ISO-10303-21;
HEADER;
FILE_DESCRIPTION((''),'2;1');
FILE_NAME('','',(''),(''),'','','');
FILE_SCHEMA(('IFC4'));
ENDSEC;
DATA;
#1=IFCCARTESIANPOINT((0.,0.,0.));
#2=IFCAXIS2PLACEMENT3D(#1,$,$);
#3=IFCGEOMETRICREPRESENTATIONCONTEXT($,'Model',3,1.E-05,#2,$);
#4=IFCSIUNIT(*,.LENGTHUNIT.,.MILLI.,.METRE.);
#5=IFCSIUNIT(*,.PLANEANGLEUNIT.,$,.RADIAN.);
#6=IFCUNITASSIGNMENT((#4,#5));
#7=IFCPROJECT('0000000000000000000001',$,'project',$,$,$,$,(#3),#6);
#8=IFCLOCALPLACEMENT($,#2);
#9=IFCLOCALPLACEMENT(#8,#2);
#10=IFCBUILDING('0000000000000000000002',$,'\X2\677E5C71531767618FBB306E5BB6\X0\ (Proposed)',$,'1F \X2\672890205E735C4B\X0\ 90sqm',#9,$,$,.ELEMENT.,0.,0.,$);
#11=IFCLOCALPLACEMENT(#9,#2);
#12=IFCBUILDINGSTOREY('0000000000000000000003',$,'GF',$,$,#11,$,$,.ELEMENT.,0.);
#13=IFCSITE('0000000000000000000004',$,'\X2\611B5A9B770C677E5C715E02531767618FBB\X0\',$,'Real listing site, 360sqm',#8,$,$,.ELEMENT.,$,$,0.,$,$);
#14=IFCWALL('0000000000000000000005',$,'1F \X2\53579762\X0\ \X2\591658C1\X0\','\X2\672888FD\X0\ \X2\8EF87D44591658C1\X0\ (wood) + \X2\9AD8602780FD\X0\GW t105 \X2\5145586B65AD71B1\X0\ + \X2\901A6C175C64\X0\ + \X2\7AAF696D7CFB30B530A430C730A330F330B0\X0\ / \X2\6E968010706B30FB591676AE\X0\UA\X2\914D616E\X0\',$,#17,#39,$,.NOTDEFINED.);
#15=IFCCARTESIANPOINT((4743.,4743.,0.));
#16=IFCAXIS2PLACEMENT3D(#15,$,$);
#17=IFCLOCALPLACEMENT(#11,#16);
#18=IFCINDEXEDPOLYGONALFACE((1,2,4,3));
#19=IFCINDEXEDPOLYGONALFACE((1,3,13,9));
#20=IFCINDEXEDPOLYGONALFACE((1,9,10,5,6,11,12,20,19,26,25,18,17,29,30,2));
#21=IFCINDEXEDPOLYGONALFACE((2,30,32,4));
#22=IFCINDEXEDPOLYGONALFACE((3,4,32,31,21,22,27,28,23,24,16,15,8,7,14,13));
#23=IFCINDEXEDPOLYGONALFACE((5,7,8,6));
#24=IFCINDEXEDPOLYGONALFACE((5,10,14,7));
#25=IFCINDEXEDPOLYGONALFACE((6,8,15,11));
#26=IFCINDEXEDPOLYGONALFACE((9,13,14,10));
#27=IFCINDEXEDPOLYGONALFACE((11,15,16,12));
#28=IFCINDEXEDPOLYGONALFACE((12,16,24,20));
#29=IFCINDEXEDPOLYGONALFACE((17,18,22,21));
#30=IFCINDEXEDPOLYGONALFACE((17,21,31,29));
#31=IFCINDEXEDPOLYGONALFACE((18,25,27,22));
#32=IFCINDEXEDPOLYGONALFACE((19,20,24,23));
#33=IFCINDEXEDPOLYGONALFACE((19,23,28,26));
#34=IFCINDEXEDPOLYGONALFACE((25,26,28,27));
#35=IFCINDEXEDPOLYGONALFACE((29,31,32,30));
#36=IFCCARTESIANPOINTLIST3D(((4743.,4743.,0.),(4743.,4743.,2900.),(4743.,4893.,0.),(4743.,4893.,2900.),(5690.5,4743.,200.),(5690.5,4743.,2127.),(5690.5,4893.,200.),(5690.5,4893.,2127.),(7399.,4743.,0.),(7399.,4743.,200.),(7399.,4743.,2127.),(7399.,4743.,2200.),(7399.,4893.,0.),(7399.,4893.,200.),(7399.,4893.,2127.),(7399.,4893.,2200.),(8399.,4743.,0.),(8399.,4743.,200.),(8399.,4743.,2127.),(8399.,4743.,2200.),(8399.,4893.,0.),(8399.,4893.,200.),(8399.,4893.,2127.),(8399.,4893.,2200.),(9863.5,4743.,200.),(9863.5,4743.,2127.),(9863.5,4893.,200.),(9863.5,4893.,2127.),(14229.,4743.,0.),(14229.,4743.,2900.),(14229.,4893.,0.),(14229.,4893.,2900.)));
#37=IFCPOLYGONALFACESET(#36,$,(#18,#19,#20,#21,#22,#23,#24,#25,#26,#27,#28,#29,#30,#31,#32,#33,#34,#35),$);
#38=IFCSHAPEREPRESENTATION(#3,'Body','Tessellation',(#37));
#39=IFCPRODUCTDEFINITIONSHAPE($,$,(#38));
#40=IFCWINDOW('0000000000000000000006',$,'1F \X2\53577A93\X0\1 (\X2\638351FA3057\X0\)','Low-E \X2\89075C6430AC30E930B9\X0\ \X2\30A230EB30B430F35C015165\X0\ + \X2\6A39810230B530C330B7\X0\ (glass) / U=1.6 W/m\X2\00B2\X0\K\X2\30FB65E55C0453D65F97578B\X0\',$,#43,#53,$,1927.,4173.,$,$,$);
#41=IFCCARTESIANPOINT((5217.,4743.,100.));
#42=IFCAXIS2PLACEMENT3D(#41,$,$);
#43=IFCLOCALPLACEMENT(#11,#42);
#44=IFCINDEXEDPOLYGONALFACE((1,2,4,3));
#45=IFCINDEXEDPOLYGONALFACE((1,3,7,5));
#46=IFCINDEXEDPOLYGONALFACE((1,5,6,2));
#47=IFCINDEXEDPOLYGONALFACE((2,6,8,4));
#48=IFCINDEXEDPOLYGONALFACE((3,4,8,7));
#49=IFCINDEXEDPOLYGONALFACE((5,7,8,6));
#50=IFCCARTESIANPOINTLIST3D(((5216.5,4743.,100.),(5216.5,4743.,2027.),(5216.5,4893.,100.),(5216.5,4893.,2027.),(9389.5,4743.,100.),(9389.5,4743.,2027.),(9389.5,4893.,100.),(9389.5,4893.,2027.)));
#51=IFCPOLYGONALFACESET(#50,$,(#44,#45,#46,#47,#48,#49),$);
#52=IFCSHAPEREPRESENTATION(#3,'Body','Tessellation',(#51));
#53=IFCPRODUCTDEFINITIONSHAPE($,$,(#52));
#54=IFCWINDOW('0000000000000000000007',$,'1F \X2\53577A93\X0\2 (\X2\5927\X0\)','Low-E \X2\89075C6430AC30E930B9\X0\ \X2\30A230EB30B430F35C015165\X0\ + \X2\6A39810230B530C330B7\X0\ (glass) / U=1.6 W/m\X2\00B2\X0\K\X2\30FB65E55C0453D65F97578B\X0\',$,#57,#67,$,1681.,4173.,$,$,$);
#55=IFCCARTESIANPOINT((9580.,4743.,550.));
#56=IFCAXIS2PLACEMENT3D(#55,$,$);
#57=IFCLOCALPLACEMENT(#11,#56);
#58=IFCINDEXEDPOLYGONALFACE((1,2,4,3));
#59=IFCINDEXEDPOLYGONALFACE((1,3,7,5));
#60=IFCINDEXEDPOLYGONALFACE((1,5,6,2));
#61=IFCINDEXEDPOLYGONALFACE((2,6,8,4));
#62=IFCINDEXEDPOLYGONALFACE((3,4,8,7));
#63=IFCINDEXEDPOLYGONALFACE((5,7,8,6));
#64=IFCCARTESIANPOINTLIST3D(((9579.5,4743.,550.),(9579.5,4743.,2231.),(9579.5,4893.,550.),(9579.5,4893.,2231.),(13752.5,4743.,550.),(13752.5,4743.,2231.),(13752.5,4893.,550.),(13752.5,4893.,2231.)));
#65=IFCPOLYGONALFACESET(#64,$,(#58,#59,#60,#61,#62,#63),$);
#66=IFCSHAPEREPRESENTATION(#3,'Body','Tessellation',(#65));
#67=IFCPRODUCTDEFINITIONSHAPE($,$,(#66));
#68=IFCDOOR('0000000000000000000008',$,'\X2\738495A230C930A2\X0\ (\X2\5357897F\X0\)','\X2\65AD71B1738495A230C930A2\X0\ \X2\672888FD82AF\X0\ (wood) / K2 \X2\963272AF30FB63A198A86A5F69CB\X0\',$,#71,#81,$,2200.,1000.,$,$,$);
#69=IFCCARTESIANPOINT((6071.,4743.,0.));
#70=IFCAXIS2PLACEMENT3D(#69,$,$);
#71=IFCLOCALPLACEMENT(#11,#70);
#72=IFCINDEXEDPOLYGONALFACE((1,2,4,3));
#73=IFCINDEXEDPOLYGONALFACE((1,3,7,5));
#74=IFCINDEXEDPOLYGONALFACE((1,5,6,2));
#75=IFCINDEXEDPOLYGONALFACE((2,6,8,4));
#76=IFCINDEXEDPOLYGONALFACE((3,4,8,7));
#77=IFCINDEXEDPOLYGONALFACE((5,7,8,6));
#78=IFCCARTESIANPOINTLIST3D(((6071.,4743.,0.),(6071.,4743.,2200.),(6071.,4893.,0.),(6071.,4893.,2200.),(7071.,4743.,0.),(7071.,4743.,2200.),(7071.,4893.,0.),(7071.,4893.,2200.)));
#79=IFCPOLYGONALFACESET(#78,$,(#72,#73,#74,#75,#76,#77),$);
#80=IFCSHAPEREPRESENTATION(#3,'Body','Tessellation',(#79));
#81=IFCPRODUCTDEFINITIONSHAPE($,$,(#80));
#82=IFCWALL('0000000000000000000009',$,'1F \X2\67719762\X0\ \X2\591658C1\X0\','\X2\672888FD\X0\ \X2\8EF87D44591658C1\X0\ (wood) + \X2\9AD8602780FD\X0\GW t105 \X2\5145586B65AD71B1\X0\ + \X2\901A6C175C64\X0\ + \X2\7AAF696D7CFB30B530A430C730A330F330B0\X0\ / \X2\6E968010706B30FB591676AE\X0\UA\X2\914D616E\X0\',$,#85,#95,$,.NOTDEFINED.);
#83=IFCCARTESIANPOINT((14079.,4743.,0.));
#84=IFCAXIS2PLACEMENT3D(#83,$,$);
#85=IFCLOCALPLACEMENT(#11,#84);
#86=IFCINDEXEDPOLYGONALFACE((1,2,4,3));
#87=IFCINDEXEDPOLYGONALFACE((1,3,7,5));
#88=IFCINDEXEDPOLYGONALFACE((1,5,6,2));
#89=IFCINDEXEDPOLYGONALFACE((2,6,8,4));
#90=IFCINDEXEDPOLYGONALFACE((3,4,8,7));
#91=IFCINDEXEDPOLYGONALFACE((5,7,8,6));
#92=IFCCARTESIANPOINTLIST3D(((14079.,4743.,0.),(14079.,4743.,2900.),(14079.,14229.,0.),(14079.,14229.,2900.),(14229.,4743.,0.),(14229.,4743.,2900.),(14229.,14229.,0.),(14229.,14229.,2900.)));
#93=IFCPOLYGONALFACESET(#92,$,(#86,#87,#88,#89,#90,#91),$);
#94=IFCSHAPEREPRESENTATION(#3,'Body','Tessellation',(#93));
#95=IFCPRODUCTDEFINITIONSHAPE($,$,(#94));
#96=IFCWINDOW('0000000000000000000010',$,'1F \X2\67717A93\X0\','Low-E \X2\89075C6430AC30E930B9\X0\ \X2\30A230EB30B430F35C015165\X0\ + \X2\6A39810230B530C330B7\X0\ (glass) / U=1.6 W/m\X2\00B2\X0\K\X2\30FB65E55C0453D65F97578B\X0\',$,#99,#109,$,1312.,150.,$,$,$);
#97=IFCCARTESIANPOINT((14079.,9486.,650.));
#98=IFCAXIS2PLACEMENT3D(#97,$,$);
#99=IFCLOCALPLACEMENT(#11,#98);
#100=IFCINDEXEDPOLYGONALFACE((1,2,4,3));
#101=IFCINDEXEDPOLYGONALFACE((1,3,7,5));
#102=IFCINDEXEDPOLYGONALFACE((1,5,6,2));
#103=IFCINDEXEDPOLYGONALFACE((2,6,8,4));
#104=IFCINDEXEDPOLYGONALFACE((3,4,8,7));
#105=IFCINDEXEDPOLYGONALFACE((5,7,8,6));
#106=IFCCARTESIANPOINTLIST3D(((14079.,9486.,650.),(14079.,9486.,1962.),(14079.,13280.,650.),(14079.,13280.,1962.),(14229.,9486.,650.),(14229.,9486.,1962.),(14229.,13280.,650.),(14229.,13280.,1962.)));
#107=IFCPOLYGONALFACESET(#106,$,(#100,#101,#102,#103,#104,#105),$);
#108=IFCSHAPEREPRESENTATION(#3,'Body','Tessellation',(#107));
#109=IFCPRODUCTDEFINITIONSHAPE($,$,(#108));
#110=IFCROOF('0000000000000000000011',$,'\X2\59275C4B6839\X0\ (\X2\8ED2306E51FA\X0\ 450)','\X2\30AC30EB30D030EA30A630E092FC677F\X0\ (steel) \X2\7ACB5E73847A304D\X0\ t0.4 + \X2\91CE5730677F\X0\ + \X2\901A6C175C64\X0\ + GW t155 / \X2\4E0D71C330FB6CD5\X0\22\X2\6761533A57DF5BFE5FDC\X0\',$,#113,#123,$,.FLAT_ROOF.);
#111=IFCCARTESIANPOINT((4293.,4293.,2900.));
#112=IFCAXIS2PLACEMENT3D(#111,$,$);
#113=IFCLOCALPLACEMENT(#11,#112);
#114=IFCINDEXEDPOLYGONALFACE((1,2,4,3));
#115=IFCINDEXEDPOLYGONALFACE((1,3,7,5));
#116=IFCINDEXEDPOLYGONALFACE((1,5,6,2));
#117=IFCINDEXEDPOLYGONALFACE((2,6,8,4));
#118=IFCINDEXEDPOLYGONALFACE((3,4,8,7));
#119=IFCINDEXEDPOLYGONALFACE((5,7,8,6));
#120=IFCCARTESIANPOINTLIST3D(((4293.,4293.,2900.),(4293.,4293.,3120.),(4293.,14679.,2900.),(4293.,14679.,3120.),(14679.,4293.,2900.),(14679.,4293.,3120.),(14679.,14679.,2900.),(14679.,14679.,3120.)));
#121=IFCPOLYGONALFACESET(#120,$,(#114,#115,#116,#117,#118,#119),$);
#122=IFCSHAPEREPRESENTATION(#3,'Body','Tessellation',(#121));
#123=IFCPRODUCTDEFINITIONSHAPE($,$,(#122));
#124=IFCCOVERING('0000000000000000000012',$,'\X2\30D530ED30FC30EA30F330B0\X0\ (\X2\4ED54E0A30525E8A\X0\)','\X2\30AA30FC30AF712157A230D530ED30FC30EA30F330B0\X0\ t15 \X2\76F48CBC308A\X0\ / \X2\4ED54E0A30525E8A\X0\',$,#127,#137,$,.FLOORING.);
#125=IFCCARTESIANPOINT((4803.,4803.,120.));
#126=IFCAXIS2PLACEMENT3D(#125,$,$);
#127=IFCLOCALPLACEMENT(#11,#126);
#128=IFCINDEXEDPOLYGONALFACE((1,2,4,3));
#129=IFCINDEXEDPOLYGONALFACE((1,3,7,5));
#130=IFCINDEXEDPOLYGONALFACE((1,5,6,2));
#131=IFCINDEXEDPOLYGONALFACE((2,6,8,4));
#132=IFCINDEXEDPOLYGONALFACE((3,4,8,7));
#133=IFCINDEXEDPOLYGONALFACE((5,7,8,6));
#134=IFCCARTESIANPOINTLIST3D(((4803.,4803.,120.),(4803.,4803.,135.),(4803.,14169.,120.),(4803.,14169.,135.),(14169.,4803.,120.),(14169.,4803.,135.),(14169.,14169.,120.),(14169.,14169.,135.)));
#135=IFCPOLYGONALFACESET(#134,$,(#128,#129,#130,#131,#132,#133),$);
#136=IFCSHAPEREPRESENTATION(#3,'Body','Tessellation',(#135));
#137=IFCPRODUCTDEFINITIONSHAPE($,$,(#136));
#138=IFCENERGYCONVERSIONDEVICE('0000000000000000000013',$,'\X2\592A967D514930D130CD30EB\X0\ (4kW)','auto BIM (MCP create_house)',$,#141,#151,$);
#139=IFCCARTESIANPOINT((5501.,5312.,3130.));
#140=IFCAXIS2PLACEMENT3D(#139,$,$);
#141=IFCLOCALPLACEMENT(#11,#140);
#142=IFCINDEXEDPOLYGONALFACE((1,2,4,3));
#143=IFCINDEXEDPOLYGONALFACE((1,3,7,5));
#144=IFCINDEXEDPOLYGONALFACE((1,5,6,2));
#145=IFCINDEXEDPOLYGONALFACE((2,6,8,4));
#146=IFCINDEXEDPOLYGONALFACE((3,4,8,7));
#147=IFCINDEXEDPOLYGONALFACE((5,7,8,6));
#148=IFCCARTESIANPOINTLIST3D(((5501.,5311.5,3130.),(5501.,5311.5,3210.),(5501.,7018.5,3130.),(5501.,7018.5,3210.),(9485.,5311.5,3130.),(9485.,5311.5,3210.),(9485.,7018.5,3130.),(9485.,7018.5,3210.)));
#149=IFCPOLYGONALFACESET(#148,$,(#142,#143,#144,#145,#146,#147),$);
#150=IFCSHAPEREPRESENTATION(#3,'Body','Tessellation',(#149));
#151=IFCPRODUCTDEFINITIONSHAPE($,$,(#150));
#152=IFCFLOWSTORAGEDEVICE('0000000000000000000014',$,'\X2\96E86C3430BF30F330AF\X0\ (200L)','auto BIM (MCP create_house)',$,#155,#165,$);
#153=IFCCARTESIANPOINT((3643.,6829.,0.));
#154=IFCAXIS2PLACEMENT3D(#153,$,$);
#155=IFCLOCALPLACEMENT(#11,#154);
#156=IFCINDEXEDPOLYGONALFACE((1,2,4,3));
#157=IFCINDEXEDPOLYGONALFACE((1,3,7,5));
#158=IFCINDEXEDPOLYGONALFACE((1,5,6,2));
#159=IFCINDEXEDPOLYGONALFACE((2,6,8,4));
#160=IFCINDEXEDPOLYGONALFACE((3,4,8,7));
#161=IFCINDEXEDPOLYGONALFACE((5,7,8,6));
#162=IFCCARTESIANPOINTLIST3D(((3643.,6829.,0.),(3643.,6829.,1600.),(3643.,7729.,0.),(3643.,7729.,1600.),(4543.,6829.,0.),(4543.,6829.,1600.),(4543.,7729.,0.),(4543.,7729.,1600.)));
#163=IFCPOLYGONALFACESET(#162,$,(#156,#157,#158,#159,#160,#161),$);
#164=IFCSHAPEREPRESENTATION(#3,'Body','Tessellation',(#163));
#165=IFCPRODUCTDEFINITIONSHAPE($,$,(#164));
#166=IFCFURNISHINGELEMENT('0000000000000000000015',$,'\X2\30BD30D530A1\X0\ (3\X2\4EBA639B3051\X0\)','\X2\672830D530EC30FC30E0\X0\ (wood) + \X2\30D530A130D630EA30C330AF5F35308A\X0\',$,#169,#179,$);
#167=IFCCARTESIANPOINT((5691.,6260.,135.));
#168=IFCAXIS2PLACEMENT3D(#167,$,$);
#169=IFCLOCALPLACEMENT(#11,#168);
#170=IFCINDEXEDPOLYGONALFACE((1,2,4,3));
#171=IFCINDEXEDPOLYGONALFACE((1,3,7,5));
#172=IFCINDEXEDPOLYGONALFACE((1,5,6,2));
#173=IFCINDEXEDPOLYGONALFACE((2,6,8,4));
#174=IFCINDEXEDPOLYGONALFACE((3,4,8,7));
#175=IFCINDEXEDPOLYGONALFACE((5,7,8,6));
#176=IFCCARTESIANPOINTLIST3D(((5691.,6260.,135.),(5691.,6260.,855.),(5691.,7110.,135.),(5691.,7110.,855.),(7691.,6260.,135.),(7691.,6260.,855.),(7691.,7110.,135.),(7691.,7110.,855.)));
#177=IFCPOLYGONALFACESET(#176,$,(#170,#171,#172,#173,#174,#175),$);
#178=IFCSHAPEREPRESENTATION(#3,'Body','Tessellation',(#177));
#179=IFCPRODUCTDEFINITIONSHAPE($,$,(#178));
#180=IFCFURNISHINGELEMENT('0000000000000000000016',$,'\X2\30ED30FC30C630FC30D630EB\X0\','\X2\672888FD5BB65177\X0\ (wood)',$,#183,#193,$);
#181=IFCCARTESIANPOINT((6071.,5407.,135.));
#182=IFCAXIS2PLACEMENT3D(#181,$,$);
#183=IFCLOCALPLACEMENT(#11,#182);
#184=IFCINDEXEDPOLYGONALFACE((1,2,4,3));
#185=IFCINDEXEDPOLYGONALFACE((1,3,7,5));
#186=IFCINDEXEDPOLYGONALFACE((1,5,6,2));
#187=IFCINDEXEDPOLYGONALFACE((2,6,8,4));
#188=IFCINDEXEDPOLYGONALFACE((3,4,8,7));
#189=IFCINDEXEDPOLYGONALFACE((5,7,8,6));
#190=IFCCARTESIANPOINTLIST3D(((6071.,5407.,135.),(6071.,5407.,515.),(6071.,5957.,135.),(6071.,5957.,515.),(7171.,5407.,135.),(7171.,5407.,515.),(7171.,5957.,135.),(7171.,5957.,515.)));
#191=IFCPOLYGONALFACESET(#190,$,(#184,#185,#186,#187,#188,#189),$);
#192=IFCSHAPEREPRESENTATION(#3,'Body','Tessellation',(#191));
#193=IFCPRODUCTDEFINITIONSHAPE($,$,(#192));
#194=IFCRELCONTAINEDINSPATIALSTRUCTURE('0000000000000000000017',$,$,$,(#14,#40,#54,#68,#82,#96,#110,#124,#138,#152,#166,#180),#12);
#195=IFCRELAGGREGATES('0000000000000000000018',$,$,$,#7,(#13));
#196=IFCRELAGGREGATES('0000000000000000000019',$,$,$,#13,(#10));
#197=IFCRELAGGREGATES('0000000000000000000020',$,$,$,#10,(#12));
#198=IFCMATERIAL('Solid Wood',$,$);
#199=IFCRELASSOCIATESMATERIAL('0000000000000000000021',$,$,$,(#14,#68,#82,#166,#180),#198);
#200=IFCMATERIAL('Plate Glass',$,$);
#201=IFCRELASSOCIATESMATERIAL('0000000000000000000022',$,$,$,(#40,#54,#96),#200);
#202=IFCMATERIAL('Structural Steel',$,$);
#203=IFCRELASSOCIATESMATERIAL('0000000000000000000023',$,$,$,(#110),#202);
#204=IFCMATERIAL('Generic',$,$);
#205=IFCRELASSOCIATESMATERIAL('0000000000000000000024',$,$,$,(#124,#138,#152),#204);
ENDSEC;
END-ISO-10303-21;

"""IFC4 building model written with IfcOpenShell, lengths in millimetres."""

from ifc_helpers import new_model, si_unit, frame, frame_2d, origin, place, context, project, spatial, rectangle, extrude, material, element, fill, save


model = new_model("IFC4")

# Units and contexts
model_context = context("Model", 3, precision=1e-05, world=origin())
ifc_project = project(units=[si_unit("LENGTHUNIT", "METRE", prefix="MILLI"), si_unit("PLANEANGLEUNIT", "RADIAN")], contexts=[model_context])

# Site, building, storey
site_placement = place(None, origin())
site = spatial("IfcSite", under=ifc_project, at=site_placement, Name="愛媛県松山市北条辻", ObjectType="Real listing site, 360sqm", CompositionType="ELEMENT", RefElevation=0.0)
building_placement = place(site_placement, origin())
building = spatial("IfcBuilding", under=site, at=building_placement, Name="松山北条辻の家 (Proposed)", ObjectType="1F 木造平屋 90sqm", CompositionType="ELEMENT", ElevationOfRefHeight=0.0, ElevationOfTerrain=0.0)
storey_placement = place(building_placement, origin())
storey = spatial("IfcBuildingStorey", under=building, at=storey_placement, Name="GF", CompositionType="ELEMENT", Elevation=0.0)

# Shared definitions
ifc_material_1 = material(Name="Solid Wood")

# Wall, openings, windows, door
wall_1_placement = place(storey_placement, frame((4743.0, 4743.0, 0.0)))
wall_1 = element("IfcWall", 1, at=wall_1_placement, inside=storey, material=ifc_material_1, Name="1F 南面 外壁", Description="木製 軸組外壁 (wood) + 高性能GW t105 充填断熱 + 通気層 + 窯業系サイディング / 準耐火・外皮UA配慮", PredefinedType="NOTDEFINED", context=model_context, shape_type="SweptSolid", body=[
    extrude(rectangle(XDim=9486.0, YDim=150.0, at=frame_2d((4743.0, 75.0))), frame((4743.0, 4743.0, 0.0)), (0.0, 0.0, 1.0), 2900.0),
])
opening_1_placement = place(storey_placement, frame((5217.0, 4743.0, 100.0)))
opening_1 = element("IfcOpeningElement", 2, at=opening_1_placement, cuts=wall_1, PredefinedType="NOTDEFINED", context=model_context, shape_type="SweptSolid", body=[
    extrude(rectangle(XDim=4173.0, YDim=150.0, at=frame_2d((2086.0, 75.0))), frame((5217.0, 4743.0, 100.0)), (0.0, 0.0, 1.0), 1927.0),
])
opening_2_placement = place(storey_placement, frame((9580.0, 4743.0, 550.0)))
opening_2 = element("IfcOpeningElement", 3, at=opening_2_placement, cuts=wall_1, PredefinedType="NOTDEFINED", context=model_context, shape_type="SweptSolid", body=[
    extrude(rectangle(XDim=4173.0, YDim=150.0, at=frame_2d((2086.0, 75.0))), frame((9580.0, 4743.0, 550.0)), (0.0, 0.0, 1.0), 1681.0),
])
opening_3_placement = place(storey_placement, frame((6071.0, 4743.0, 0.0)))
opening_3 = element("IfcOpeningElement", 4, at=opening_3_placement, cuts=wall_1, PredefinedType="NOTDEFINED", context=model_context, shape_type="SweptSolid", body=[
    extrude(rectangle(XDim=1000.0, YDim=150.0, at=frame_2d((500.0, 75.0))), frame((6071.0, 4743.0, 0.0)), (0.0, 0.0, 1.0), 2200.0),
])
ifc_material_2 = material(Name="Plate Glass")
window_1_placement = place(storey_placement, frame((5217.0, 4743.0, 100.0)))
window_1 = element("IfcWindow", 5, at=window_1_placement, inside=storey, material=ifc_material_2, Name="1F 南窓1 (掃出し)", Description="Low-E 複層ガラス アルゴン封入 + 樹脂サッシ (glass) / U=1.6 W/m²K・日射取得型", OverallHeight=1927.0, OverallWidth=4173.0, context=model_context, shape_type="SweptSolid", body=[
    extrude(rectangle(XDim=4173.0, YDim=150.0, at=frame_2d((2086.0, 75.0))), frame((5217.0, 4743.0, 100.0)), (0.0, 0.0, 1.0), 1927.0),
])
fill(opening_1, window_1)
window_2_placement = place(storey_placement, frame((9580.0, 4743.0, 550.0)))
window_2 = element("IfcWindow", 6, at=window_2_placement, inside=storey, material=ifc_material_2, Name="1F 南窓2 (大)", Description="Low-E 複層ガラス アルゴン封入 + 樹脂サッシ (glass) / U=1.6 W/m²K・日射取得型", OverallHeight=1681.0, OverallWidth=4173.0, context=model_context, shape_type="SweptSolid", body=[
    extrude(rectangle(XDim=4173.0, YDim=150.0, at=frame_2d((2086.0, 75.0))), frame((9580.0, 4743.0, 550.0)), (0.0, 0.0, 1.0), 1681.0),
])
fill(opening_2, window_2)
door_placement = place(storey_placement, frame((6071.0, 4743.0, 0.0)))
door = element("IfcDoor", 7, at=door_placement, inside=storey, material=ifc_material_1, Name="玄関ドア (南西)", Description="断熱玄関ドア 木製芯 (wood) / K2 防犯・採風機構", OverallHeight=2200.0, OverallWidth=1000.0, context=model_context, shape_type="SweptSolid", body=[
    extrude(rectangle(XDim=1000.0, YDim=150.0, at=frame_2d((500.0, 75.0))), frame((6071.0, 4743.0, 0.0)), (0.0, 0.0, 1.0), 2200.0),
])
fill(opening_3, door)

# Wall, opening, window
wall_2_placement = place(storey_placement, frame((14079.0, 4743.0, 0.0)))
wall_2 = element("IfcWall", 8, at=wall_2_placement, inside=storey, material=ifc_material_1, Name="1F 東面 外壁", Description="木製 軸組外壁 (wood) + 高性能GW t105 充填断熱 + 通気層 + 窯業系サイディング / 準耐火・外皮UA配慮", PredefinedType="NOTDEFINED", context=model_context, shape_type="SweptSolid", body=[
    extrude(rectangle(XDim=150.0, YDim=9486.0, at=frame_2d((75.0, 4743.0))), frame((14079.0, 4743.0, 0.0)), (0.0, 0.0, 1.0), 2900.0),
])
opening_4_placement = place(storey_placement, frame((14079.0, 9486.0, 650.0)))
opening_4 = element("IfcOpeningElement", 9, at=opening_4_placement, cuts=wall_2, PredefinedType="NOTDEFINED", context=model_context, shape_type="SweptSolid", body=[
    extrude(rectangle(XDim=150.0, YDim=3794.0, at=frame_2d((75.0, 1897.0))), frame((14079.0, 9486.0, 650.0)), (0.0, 0.0, 1.0), 1312.0),
])
window_3_placement = place(storey_placement, frame((14079.0, 9486.0, 650.0)))
window_3 = element("IfcWindow", 10, at=window_3_placement, inside=storey, material=ifc_material_2, Name="1F 東窓", Description="Low-E 複層ガラス アルゴン封入 + 樹脂サッシ (glass) / U=1.6 W/m²K・日射取得型", OverallHeight=1312.0, OverallWidth=150.0, context=model_context, shape_type="SweptSolid", body=[
    extrude(rectangle(XDim=150.0, YDim=3794.0, at=frame_2d((75.0, 1897.0))), frame((14079.0, 9486.0, 650.0)), (0.0, 0.0, 1.0), 1312.0),
])
fill(opening_4, window_3)

# Roof
ifc_material_3 = material(Name="Structural Steel")
roof_placement = place(storey_placement, frame((4293.0, 4293.0, 2900.0)))
element("IfcRoof", 11, at=roof_placement, inside=storey, material=ifc_material_3, Name="大屋根 (軒の出 450)", Description="ガルバリウム鋼板 (steel) 立平葺き t0.4 + 野地板 + 通気層 + GW t155 / 不燃・法22条区域対応", PredefinedType="FLAT_ROOF", context=model_context, shape_type="SweptSolid", body=[
    extrude(rectangle(XDim=10386.0, YDim=10386.0, at=frame_2d((5193.0, 5193.0))), frame((4293.0, 4293.0, 2900.0)), (0.0, 0.0, 1.0), 220.0),
])

# Covering
ifc_material_4 = material(Name="Generic")
covering_placement = place(storey_placement, frame((4803.0, 4803.0, 120.0)))
element("IfcCovering", 12, at=covering_placement, inside=storey, material=ifc_material_4, Name="フローリング (仕上げ床)", Description="オーク無垢フローリング t15 直貼り / 仕上げ床", PredefinedType="FLOORING", context=model_context, shape_type="SweptSolid", body=[
    extrude(rectangle(XDim=9366.0, YDim=9366.0, at=frame_2d((4683.0, 4683.0))), frame((4803.0, 4803.0, 120.0)), (0.0, 0.0, 1.0), 15.0),
])

# Energy conversion device
energy_conversion_device_placement = place(storey_placement, frame((5501.0, 5312.0, 3130.0)))
element("IfcEnergyConversionDevice", 13, at=energy_conversion_device_placement, inside=storey, material=ifc_material_4, Name="太陽光パネル (4kW)", Description="auto BIM (MCP create_house)", context=model_context, shape_type="SweptSolid", body=[
    extrude(rectangle(XDim=3984.0, YDim=1707.0, at=frame_2d((1992.0, 853.0))), frame((5501.0, 5312.0, 3130.0)), (0.0, 0.0, 1.0), 80.0),
])

# Flow storage device
flow_storage_device_placement = place(storey_placement, frame((3643.0, 6829.0, 0.0)))
element("IfcFlowStorageDevice", 14, at=flow_storage_device_placement, inside=storey, material=ifc_material_4, Name="雨水タンク (200L)", Description="auto BIM (MCP create_house)", context=model_context, shape_type="SweptSolid", body=[
    extrude(rectangle(XDim=900.0, YDim=900.0, at=frame_2d((450.0, 450.0))), frame((3643.0, 6829.0, 0.0)), (0.0, 0.0, 1.0), 1600.0),
])

# Furnishing elements
furnishing_1_placement = place(storey_placement, frame((5691.0, 6260.0, 135.0)))
element("IfcFurnishingElement", 15, at=furnishing_1_placement, inside=storey, material=ifc_material_1, Name="ソファ (3人掛け)", Description="木フレーム (wood) + ファブリック張り", context=model_context, shape_type="SweptSolid", body=[
    extrude(rectangle(XDim=2000.0, YDim=850.0, at=frame_2d((1000.0, 425.0))), frame((5691.0, 6260.0, 135.0)), (0.0, 0.0, 1.0), 720.0),
])
furnishing_2_placement = place(storey_placement, frame((6071.0, 5407.0, 135.0)))
element("IfcFurnishingElement", 16, at=furnishing_2_placement, inside=storey, material=ifc_material_1, Name="ローテーブル", Description="木製家具 (wood)", context=model_context, shape_type="SweptSolid", body=[
    extrude(rectangle(XDim=1100.0, YDim=550.0, at=frame_2d((550.0, 275.0))), frame((6071.0, 5407.0, 135.0)), (0.0, 0.0, 1.0), 380.0),
])

save(model, "model.ifc")
